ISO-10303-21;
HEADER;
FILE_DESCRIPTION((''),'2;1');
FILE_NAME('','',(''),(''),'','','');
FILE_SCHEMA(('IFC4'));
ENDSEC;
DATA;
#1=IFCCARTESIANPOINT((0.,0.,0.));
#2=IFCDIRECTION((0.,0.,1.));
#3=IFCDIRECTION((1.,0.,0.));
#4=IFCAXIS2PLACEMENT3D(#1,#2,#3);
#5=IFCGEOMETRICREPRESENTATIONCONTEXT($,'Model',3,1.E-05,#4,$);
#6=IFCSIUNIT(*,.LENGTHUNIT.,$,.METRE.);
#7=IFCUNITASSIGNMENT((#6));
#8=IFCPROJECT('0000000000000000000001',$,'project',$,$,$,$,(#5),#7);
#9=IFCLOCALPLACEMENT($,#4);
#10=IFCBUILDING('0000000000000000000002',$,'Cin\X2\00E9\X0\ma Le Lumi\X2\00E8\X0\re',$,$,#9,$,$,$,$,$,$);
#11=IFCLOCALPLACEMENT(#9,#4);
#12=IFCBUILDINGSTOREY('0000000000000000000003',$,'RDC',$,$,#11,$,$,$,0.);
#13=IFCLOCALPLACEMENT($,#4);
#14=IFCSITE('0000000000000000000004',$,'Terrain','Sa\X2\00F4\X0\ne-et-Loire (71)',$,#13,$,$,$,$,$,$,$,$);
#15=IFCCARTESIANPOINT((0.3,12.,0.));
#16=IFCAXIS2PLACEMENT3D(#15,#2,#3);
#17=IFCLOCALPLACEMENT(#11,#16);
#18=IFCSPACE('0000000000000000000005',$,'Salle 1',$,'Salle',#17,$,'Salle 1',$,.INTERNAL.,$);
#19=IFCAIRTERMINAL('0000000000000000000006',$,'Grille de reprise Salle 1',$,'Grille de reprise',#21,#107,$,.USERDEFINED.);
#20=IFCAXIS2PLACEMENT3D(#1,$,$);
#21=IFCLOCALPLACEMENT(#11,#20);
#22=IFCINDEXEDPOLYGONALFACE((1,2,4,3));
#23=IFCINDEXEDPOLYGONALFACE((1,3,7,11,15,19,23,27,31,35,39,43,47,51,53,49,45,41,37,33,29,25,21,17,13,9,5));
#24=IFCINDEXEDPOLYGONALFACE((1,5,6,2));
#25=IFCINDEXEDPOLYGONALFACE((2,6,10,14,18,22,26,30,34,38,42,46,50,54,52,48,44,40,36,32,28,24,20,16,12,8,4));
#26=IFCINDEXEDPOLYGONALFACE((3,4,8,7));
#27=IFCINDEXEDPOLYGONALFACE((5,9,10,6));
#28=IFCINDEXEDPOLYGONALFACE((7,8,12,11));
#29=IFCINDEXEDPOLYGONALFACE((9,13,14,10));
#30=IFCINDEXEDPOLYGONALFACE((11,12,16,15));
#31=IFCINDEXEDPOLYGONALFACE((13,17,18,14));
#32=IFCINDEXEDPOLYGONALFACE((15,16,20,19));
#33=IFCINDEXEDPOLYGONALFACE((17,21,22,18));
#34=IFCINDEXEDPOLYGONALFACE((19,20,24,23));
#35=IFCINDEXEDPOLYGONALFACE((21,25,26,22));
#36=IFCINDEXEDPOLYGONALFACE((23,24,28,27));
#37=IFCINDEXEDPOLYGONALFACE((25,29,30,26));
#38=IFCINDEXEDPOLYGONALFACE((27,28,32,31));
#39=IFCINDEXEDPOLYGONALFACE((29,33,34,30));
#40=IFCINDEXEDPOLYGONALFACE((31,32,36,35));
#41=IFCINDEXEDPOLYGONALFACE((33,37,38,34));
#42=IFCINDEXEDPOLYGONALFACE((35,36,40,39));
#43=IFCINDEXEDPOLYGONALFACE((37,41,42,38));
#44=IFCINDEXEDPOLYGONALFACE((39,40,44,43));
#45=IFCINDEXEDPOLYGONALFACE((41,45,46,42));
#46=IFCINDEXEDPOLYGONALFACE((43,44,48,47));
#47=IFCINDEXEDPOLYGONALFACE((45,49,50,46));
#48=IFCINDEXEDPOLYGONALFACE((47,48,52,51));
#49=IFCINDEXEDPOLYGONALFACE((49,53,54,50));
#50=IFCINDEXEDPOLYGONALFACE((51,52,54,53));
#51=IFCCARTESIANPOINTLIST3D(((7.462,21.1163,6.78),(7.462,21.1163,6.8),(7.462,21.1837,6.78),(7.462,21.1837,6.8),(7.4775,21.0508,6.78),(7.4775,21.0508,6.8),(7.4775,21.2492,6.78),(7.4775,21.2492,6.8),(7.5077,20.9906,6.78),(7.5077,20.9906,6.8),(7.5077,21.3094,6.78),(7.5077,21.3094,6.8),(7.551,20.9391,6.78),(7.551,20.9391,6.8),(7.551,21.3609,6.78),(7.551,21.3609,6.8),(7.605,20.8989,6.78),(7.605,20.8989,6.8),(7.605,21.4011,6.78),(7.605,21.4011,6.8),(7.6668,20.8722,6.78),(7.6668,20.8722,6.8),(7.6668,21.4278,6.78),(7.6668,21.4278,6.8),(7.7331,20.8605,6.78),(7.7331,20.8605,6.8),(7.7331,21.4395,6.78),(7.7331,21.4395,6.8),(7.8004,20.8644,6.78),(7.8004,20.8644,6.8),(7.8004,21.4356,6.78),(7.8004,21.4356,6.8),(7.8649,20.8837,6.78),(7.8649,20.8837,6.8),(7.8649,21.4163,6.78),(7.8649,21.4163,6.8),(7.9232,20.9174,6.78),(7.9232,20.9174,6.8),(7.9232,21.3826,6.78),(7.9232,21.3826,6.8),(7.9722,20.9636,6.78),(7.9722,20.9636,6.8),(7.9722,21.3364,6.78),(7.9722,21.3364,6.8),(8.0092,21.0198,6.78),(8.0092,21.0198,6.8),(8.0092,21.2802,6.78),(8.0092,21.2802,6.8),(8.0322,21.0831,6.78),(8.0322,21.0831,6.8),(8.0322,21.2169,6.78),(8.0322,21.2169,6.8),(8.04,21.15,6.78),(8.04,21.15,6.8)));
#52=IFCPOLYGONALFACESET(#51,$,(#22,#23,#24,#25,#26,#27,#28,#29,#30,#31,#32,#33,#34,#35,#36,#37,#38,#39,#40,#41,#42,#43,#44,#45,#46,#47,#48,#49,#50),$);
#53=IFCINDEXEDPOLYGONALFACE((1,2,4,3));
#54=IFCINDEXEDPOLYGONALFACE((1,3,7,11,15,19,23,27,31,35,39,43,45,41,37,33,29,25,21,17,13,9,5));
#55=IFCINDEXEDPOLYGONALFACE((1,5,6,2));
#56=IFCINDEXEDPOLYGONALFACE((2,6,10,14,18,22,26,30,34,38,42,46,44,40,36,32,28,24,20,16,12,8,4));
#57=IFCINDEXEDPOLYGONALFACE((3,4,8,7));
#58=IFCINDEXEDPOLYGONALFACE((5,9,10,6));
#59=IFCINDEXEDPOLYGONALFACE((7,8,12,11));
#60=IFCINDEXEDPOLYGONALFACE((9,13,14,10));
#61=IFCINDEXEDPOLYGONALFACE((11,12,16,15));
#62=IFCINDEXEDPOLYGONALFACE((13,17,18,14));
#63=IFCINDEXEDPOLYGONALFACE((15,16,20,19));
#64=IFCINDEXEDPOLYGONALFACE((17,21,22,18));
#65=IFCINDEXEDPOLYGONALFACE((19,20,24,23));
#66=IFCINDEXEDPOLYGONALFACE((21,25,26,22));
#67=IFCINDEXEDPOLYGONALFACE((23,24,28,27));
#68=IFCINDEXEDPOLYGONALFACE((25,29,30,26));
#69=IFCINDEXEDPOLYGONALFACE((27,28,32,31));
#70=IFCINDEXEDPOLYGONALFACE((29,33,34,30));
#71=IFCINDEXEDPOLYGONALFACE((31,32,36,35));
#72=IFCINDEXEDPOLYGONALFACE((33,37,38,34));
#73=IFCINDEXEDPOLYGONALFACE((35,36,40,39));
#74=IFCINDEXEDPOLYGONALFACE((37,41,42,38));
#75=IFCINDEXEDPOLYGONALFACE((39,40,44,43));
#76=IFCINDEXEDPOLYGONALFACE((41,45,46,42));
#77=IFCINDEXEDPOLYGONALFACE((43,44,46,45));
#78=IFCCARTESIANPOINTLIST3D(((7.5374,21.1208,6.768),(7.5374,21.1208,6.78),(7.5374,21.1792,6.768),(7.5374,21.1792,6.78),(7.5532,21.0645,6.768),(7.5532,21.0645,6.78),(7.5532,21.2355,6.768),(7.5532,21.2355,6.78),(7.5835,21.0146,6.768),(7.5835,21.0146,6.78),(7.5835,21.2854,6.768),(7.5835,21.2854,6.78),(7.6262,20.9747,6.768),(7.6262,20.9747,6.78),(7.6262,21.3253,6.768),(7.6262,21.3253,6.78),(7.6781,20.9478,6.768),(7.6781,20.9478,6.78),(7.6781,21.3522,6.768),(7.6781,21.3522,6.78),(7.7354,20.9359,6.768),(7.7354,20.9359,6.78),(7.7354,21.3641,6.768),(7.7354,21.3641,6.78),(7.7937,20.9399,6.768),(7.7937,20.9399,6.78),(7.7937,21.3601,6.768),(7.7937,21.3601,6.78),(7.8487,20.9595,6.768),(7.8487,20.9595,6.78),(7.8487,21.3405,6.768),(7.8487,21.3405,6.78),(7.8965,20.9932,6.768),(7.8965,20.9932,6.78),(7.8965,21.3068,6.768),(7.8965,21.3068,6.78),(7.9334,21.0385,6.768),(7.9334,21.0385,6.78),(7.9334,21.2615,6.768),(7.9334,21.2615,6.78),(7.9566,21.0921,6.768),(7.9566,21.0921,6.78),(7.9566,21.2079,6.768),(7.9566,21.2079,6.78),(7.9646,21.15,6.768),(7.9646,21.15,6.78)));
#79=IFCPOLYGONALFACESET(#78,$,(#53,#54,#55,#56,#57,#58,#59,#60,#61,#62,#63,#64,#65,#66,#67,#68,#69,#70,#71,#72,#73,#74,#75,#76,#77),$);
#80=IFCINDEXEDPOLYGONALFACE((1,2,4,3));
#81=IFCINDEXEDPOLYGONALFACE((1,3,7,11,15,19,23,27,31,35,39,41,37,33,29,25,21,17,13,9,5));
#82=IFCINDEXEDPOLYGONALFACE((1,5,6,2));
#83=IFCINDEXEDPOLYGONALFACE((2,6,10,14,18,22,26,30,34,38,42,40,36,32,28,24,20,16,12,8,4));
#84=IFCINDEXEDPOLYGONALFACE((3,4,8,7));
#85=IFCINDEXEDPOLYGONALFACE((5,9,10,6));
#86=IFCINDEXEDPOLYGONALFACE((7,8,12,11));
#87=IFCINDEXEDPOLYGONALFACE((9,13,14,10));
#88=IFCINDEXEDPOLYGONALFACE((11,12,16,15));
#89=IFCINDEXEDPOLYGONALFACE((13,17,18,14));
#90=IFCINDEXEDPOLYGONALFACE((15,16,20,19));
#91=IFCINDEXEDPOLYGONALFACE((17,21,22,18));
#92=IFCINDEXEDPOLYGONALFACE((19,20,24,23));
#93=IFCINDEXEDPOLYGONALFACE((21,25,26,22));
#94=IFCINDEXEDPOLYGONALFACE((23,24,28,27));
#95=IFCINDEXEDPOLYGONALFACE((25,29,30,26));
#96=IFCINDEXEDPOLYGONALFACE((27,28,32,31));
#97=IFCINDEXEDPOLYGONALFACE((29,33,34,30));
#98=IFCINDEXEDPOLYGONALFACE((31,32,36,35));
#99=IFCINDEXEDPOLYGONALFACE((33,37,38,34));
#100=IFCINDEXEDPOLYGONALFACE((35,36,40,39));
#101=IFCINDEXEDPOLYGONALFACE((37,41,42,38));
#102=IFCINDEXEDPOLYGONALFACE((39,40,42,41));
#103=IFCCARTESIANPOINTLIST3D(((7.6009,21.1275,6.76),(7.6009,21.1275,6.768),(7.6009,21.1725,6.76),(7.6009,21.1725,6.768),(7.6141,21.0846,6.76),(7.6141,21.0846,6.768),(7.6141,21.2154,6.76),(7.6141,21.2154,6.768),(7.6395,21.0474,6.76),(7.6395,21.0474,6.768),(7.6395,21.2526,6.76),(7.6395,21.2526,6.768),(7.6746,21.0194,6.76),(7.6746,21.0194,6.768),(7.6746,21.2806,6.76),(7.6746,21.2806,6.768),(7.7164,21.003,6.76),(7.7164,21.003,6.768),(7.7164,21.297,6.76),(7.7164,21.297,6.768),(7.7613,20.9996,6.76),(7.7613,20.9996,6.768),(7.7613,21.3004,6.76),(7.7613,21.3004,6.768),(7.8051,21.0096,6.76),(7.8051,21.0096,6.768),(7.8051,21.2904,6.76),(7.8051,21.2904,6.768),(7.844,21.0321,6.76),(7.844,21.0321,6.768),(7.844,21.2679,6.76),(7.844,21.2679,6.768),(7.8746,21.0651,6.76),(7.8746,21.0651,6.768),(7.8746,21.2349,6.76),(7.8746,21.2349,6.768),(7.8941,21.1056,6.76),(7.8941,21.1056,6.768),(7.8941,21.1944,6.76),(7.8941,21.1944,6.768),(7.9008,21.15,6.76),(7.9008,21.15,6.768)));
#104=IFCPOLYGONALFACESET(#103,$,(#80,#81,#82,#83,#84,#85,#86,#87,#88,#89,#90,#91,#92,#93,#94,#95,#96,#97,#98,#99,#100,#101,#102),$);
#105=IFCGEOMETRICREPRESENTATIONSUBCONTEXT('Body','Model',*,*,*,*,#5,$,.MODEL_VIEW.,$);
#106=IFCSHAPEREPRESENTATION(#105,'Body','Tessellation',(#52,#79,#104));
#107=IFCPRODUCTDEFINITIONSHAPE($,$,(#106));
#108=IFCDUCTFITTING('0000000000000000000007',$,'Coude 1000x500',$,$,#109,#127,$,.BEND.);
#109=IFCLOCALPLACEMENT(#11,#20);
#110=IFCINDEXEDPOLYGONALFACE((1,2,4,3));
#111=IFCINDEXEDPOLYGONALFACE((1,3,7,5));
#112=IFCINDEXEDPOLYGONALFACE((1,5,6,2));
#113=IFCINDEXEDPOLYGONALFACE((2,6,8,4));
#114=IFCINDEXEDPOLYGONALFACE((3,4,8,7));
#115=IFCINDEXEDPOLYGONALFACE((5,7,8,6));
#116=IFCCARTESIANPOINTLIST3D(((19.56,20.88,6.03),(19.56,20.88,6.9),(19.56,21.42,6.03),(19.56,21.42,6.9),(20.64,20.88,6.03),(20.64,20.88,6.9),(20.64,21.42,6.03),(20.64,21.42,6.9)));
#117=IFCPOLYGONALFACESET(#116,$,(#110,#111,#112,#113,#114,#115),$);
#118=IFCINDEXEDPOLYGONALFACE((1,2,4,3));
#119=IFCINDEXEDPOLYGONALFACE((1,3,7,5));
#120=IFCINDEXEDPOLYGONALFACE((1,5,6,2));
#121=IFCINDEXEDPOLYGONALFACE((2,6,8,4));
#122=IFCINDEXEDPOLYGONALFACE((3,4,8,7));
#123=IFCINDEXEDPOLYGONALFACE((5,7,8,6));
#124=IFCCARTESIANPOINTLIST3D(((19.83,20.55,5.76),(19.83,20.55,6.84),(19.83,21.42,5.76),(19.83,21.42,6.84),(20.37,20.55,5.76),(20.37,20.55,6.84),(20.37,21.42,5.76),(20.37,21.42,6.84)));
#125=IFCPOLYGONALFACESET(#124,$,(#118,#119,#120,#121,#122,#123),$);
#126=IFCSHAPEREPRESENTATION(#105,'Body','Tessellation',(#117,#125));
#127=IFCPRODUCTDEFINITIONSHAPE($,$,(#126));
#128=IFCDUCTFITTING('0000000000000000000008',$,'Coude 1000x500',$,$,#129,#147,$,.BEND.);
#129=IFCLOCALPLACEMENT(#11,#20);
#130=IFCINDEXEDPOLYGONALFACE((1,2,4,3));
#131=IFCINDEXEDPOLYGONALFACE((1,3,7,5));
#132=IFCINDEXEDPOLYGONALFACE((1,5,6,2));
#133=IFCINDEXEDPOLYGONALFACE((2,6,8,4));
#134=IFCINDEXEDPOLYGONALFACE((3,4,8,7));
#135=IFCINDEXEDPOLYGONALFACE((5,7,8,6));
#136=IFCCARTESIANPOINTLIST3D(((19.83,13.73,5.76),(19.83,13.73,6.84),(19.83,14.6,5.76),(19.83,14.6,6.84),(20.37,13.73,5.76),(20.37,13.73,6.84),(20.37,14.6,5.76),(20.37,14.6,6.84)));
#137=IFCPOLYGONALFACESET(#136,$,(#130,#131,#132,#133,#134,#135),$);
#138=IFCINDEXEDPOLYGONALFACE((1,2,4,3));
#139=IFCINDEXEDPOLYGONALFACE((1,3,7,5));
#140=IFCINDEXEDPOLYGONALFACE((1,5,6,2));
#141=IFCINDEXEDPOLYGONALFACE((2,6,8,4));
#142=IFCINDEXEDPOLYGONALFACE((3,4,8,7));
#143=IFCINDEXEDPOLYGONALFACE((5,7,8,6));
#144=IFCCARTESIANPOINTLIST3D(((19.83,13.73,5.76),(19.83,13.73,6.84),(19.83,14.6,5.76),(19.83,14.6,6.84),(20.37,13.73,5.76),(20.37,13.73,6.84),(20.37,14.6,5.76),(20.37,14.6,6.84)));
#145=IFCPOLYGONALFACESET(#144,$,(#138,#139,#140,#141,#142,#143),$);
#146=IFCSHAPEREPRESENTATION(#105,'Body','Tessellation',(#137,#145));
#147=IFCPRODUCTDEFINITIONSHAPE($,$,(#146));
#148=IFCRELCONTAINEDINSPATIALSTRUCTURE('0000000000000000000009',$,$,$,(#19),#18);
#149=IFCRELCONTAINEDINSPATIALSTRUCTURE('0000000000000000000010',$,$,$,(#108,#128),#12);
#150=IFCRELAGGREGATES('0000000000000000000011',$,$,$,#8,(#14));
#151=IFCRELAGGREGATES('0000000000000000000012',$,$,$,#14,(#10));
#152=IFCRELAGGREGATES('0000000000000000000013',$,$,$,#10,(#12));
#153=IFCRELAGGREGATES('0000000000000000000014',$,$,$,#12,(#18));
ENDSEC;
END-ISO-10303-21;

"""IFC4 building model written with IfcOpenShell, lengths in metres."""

from ifc_helpers import new_model, si_unit, frame, origin_with_axes, origin_2d, place, context, subcontext, project, spatial, rectangle, circle, extrude, element, save


model = new_model("IFC4")

# Units and contexts
model_context = context("Model", 3, precision=1e-05, world=origin_with_axes())
body_context = subcontext(model_context, "Body", "Model", "MODEL_VIEW")
ifc_project = project(units=[si_unit("LENGTHUNIT", "METRE")], contexts=[model_context])

# Site, building, storey
site_placement = place(None, origin_with_axes())
site = spatial("IfcSite", under=ifc_project, at=site_placement, Name="Terrain", Description="Saône-et-Loire (71)")
building_placement = place(None, origin_with_axes())
building = spatial("IfcBuilding", under=site, at=building_placement, Name="Cinéma Le Lumière")
storey_placement = place(building_placement, origin_with_axes())
storey = spatial("IfcBuildingStorey", under=building, at=storey_placement, Name="RDC", Elevation=0.0)

# Shared definitions
space_1_placement = place(storey_placement, frame((0.3, 12.0, 0.0), z_axis=(0.0, 0.0, 1.0), x_axis=(1.0, 0.0, 0.0)))
space_1 = spatial("IfcSpace", under=storey, at=space_1_placement, Name="Salle 1", ObjectType="Salle", LongName="Salle 1", PredefinedType="INTERNAL")

# Air terminal
air_terminal_1_placement = place(space_1_placement, frame((7.45, 9.15, 6.76), z_axis=(0.0, 0.0, 1.0), x_axis=(1.0, 0.0, 0.0)))
element("IfcAirTerminal", 1, at=air_terminal_1_placement, inside=space_1, Name="Grille de reprise Salle 1", ObjectType="Grille de reprise", PredefinedType="USERDEFINED", context=body_context, shape_type="SweptSolid", body=[
    extrude(circle(Radius=0.29), frame((0.0, 0.0, 0.02), z_axis=(0.0, 0.0, 1.0), x_axis=(1.0, 0.0, 0.0)), (0.0, 0.0, 1.0), 0.02),
    extrude(circle(Radius=0.2146), frame((0.0, 0.0, 0.008), z_axis=(0.0, 0.0, 1.0), x_axis=(1.0, 0.0, 0.0)), (0.0, 0.0, 1.0), 0.012),
    extrude(circle(Radius=0.1508), origin_with_axes(), (0.0, 0.0, 1.0), 0.008),
])

# Duct fittings
duct_fitting_1_placement = place(storey_placement, frame((20.1, 21.15, 6.3), z_axis=(0.0, 0.0, 1.0), x_axis=(1.0, 0.0, 0.0)))
element("IfcDuctFitting", 2, at=duct_fitting_1_placement, inside=storey, Name="Coude 1000x500", PredefinedType="BEND", context=body_context, shape_type="SweptSolid", body=[
    extrude(rectangle(XDim=1.08, YDim=0.54, at=origin_2d()), frame((0.0, 0.0, -0.27), z_axis=(0.0, 0.0, 1.0), x_axis=(1.0, 0.0, 0.0)), (0.0, 0.0, 1.0), 0.87),
    extrude(rectangle(XDim=1.08, YDim=0.54, at=origin_2d()), frame((0.0, 0.27, 0.0), z_axis=(0.0, -1.0, 0.0), x_axis=(0.0, 0.0, 1.0)), (0.0, 0.0, 1.0), 0.87),
])
duct_fitting_2_placement = place(storey_placement, frame((20.1, 14.0, 6.3), z_axis=(0.0, 0.0, 1.0), x_axis=(1.0, 0.0, 0.0)))
element("IfcDuctFitting", 3, at=duct_fitting_2_placement, inside=storey, Name="Coude 1000x500", PredefinedType="BEND", context=body_context, shape_type="SweptSolid", body=[
    extrude(rectangle(XDim=1.08, YDim=0.54, at=origin_2d()), frame((0.0, -0.27, 0.0), z_axis=(0.0, 1.0, 0.0), x_axis=(0.0, 0.0, 1.0)), (0.0, 0.0, 1.0), 0.87),
    extrude(rectangle(XDim=1.08, YDim=0.54, at=origin_2d()), frame((0.0, -0.27, 0.0), z_axis=(0.0, 1.0, 0.0), x_axis=(0.0, 0.0, 1.0)), (0.0, 0.0, 1.0), 0.87),
])

save(model, "model.ifc")
